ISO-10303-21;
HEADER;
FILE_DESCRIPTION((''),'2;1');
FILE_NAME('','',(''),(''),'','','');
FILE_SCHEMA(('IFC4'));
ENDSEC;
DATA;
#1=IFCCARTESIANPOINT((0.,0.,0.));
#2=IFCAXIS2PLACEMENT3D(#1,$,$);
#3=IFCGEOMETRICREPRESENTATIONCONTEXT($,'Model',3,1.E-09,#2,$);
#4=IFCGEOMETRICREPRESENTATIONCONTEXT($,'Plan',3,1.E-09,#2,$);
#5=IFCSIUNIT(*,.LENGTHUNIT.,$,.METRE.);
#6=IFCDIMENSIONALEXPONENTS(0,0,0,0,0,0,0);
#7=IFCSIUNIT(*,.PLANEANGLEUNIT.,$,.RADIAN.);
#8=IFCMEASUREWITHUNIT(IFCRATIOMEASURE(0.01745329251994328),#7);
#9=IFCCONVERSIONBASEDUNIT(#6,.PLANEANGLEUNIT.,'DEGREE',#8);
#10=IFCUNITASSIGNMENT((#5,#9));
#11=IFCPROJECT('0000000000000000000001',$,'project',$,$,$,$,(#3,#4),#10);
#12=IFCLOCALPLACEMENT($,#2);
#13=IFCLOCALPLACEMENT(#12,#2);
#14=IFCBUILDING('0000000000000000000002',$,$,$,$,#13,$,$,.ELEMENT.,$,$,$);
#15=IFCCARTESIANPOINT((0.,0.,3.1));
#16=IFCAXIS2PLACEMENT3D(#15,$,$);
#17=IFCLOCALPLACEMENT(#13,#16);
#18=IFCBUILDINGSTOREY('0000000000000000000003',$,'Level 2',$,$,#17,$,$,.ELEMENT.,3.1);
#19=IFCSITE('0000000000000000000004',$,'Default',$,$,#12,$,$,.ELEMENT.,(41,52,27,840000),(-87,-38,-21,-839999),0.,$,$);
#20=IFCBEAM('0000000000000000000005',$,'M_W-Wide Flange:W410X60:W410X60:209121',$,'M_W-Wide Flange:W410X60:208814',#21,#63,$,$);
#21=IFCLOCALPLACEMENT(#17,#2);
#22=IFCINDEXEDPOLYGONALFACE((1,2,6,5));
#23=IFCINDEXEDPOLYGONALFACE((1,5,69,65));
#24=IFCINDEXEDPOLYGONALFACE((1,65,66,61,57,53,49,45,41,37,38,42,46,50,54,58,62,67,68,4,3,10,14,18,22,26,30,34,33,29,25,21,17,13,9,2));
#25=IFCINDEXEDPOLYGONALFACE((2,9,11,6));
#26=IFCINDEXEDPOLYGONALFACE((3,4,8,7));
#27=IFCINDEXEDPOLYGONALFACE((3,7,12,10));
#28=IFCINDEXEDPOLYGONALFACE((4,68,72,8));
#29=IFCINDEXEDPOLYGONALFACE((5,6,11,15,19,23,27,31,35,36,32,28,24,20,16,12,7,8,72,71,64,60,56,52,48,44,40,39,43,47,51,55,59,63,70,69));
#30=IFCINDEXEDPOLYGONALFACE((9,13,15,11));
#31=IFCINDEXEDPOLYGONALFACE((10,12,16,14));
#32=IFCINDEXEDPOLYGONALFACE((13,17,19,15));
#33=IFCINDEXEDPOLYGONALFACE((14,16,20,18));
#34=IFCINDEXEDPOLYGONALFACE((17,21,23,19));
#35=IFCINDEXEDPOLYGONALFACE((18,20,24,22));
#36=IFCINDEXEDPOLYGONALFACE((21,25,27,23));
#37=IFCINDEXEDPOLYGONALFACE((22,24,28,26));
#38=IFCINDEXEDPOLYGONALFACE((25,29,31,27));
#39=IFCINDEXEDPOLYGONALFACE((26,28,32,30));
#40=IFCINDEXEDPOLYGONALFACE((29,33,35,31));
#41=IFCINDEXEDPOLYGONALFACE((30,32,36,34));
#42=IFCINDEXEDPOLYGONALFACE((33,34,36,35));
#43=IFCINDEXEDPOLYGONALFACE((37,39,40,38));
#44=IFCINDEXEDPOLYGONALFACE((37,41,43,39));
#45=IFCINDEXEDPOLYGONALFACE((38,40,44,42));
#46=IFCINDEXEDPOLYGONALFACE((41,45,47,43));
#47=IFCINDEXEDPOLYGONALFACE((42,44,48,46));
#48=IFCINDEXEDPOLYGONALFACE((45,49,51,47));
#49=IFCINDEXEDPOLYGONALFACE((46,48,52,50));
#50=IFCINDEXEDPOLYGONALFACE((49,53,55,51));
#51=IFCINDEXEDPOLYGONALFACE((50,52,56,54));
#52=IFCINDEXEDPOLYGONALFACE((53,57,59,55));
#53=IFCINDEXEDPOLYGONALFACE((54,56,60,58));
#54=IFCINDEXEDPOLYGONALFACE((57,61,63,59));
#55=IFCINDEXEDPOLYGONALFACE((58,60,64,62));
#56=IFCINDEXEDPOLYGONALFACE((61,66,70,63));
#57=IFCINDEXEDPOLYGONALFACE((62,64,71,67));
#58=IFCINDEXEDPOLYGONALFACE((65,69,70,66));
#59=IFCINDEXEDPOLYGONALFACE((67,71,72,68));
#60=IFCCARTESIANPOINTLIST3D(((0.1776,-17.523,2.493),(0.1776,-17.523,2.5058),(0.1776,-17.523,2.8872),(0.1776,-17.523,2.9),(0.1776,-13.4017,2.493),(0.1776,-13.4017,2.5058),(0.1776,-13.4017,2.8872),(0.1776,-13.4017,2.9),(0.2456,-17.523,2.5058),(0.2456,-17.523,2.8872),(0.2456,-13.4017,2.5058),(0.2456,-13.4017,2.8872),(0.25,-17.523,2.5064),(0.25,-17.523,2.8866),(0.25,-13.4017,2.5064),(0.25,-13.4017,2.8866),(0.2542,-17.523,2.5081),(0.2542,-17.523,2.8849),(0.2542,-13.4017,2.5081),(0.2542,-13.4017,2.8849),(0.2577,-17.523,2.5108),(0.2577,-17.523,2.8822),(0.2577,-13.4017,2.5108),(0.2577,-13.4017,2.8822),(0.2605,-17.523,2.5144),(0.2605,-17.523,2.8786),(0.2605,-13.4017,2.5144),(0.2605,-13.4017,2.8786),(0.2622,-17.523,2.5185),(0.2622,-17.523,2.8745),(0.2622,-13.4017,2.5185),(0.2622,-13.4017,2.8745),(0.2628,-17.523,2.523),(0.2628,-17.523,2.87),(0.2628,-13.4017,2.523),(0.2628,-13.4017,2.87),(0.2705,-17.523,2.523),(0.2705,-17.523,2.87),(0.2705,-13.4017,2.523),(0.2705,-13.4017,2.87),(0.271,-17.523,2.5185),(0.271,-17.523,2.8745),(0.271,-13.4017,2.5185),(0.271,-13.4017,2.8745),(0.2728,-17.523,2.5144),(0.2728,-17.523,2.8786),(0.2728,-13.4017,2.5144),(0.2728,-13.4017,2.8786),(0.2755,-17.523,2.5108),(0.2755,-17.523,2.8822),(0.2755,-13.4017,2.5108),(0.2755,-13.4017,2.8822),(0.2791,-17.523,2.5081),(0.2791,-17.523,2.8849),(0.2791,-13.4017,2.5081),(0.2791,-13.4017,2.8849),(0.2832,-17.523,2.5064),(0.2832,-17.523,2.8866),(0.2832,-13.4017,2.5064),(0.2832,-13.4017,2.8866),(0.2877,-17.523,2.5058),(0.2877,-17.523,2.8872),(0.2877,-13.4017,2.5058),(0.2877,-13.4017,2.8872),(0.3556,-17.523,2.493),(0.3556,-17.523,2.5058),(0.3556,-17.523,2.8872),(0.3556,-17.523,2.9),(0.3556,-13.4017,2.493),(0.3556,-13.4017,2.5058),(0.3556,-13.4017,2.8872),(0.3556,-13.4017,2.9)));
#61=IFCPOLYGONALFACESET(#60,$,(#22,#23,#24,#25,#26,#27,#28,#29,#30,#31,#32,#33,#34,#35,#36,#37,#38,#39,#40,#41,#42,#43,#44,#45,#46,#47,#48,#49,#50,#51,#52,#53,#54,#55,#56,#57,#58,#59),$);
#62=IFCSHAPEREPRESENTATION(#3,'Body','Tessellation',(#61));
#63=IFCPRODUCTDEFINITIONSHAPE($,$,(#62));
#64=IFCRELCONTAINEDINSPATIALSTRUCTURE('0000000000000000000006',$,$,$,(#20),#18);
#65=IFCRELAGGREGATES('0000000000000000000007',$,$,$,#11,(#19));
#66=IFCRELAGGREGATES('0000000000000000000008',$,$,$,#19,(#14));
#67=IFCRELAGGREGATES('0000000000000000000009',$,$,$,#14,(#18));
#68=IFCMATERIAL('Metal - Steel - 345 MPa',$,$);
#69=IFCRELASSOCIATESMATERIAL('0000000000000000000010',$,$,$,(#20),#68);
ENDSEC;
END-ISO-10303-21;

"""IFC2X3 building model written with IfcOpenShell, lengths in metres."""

from ifc_helpers import new_model, entity, si_unit, converted_unit, frame, frame_2d, origin, place, context, project, spatial, polyline, circle_curve, parameter, trimmed, segment, composite_curve, outline, extrude, material, element, save


model = new_model("IFC2X3")

# Units and contexts
model_context = context("Model", 3, precision=1e-09, world=origin())
plan_context = context("Plan", 3, precision=1e-09, world=origin())
ifc_project = project(units=[si_unit("LENGTHUNIT", "METRE"), converted_unit("PLANEANGLEUNIT", "DEGREE", entity("IfcRatioMeasure", 0.01745329251994328), si_unit("PLANEANGLEUNIT", "RADIAN"), dimensions=[0, 0, 0, 0, 0, 0, 0])], contexts=[model_context, plan_context])

# Site, building, storey
site_placement = place(None, origin())
site = spatial("IfcSite", under=ifc_project, at=site_placement, Name="Default", CompositionType="ELEMENT", RefLatitude=(41, 52, 27, 840000), RefLongitude=(-87, -38, -21, -839999), RefElevation=0.0)
building_placement = place(site_placement, origin())
building = spatial("IfcBuilding", under=site, at=building_placement, CompositionType="ELEMENT")
storey_placement = place(building_placement, frame((0.0, 0.0, 3.1)))
storey = spatial("IfcBuildingStorey", under=building, at=storey_placement, Name="Level 2", CompositionType="ELEMENT", Elevation=3.1)

# Beam
ifc_material_1 = material(Name="Metal - Steel - 345 MPa")
beam_placement = place(storey_placement, frame((0.2666, -13.4017, 2.9), z_axis=(0.0, 0.0, 1.0), x_axis=(-1.0, 0.0, 0.0)))
element("IfcBeam", 1, at=beam_placement, inside=storey, material=ifc_material_1, Name="M_W-Wide Flange:W410X60:W410X60:209121", ObjectType="M_W-Wide Flange:W410X60:208814", context=model_context, shape_type="SweptSolid", body=[
    extrude(outline(composite_curve([segment(polyline([(0.1907, -0.089), (0.2035, -0.089)]), True, "CONTINUOUS"), segment(polyline([(0.2035, -0.089), (0.2035, 0.089)]), True, "CONTINUOUS"), segment(polyline([(0.2035, 0.089), (0.1907, 0.089)]), True, "CONTINUOUS"), segment(polyline([(0.1907, 0.089), (0.1907, 0.021)]), True, "CONTINUOUS"), segment(trimmed(circle_curve(frame_2d((0.1735, 0.021), x_axis=(1.0, 0.0)), 0.0172), [parameter(270.0)], [parameter(360.0)], True, "PARAMETER"), False, "CONTINUOUS"), segment(polyline([(0.1735, 0.0038), (-0.1735, 0.0038)]), True, "CONTINUOUS"), segment(trimmed(circle_curve(frame_2d((-0.1735, 0.021), x_axis=(0.0, -1.0)), 0.0172), [parameter(270.0)], [parameter(360.0)], True, "PARAMETER"), False, "CONTINUOUS"), segment(polyline([(-0.1907, 0.021), (-0.1907, 0.089)]), True, "CONTINUOUS"), segment(polyline([(-0.1907, 0.089), (-0.2035, 0.089)]), True, "CONTINUOUS"), segment(polyline([(-0.2035, 0.089), (-0.2035, -0.089)]), True, "CONTINUOUS"), segment(polyline([(-0.2035, -0.089), (-0.1907, -0.089)]), True, "CONTINUOUS"), segment(polyline([(-0.1907, -0.089), (-0.1907, -0.0211)]), True, "CONTINUOUS"), segment(trimmed(circle_curve(frame_2d((-0.1735, -0.0211), x_axis=(-1.0, 0.0)), 0.0172), [parameter(270.0)], [parameter(0.0)], True, "PARAMETER"), False, "CONTINUOUS"), segment(polyline([(-0.1735, -0.0039), (0.1735, -0.0039)]), True, "CONTINUOUS"), segment(trimmed(circle_curve(frame_2d((0.1735, -0.0211), x_axis=(0.0, 1.0)), 0.0172), [parameter(270.0)], [parameter(0.0)], True, "PARAMETER"), False, "CONTINUOUS"), segment(polyline([(0.1907, -0.0211), (0.1907, -0.089)]), True, "CONTINUOUS")], self_intersect=False)), frame((0.0, 4.1213, -0.2035), z_axis=(0.0, -1.0, 0.0), x_axis=(0.0, 0.0, -1.0)), (0.0, 0.0, 1.0), 4.1213),
])

save(model, "model.ifc")
